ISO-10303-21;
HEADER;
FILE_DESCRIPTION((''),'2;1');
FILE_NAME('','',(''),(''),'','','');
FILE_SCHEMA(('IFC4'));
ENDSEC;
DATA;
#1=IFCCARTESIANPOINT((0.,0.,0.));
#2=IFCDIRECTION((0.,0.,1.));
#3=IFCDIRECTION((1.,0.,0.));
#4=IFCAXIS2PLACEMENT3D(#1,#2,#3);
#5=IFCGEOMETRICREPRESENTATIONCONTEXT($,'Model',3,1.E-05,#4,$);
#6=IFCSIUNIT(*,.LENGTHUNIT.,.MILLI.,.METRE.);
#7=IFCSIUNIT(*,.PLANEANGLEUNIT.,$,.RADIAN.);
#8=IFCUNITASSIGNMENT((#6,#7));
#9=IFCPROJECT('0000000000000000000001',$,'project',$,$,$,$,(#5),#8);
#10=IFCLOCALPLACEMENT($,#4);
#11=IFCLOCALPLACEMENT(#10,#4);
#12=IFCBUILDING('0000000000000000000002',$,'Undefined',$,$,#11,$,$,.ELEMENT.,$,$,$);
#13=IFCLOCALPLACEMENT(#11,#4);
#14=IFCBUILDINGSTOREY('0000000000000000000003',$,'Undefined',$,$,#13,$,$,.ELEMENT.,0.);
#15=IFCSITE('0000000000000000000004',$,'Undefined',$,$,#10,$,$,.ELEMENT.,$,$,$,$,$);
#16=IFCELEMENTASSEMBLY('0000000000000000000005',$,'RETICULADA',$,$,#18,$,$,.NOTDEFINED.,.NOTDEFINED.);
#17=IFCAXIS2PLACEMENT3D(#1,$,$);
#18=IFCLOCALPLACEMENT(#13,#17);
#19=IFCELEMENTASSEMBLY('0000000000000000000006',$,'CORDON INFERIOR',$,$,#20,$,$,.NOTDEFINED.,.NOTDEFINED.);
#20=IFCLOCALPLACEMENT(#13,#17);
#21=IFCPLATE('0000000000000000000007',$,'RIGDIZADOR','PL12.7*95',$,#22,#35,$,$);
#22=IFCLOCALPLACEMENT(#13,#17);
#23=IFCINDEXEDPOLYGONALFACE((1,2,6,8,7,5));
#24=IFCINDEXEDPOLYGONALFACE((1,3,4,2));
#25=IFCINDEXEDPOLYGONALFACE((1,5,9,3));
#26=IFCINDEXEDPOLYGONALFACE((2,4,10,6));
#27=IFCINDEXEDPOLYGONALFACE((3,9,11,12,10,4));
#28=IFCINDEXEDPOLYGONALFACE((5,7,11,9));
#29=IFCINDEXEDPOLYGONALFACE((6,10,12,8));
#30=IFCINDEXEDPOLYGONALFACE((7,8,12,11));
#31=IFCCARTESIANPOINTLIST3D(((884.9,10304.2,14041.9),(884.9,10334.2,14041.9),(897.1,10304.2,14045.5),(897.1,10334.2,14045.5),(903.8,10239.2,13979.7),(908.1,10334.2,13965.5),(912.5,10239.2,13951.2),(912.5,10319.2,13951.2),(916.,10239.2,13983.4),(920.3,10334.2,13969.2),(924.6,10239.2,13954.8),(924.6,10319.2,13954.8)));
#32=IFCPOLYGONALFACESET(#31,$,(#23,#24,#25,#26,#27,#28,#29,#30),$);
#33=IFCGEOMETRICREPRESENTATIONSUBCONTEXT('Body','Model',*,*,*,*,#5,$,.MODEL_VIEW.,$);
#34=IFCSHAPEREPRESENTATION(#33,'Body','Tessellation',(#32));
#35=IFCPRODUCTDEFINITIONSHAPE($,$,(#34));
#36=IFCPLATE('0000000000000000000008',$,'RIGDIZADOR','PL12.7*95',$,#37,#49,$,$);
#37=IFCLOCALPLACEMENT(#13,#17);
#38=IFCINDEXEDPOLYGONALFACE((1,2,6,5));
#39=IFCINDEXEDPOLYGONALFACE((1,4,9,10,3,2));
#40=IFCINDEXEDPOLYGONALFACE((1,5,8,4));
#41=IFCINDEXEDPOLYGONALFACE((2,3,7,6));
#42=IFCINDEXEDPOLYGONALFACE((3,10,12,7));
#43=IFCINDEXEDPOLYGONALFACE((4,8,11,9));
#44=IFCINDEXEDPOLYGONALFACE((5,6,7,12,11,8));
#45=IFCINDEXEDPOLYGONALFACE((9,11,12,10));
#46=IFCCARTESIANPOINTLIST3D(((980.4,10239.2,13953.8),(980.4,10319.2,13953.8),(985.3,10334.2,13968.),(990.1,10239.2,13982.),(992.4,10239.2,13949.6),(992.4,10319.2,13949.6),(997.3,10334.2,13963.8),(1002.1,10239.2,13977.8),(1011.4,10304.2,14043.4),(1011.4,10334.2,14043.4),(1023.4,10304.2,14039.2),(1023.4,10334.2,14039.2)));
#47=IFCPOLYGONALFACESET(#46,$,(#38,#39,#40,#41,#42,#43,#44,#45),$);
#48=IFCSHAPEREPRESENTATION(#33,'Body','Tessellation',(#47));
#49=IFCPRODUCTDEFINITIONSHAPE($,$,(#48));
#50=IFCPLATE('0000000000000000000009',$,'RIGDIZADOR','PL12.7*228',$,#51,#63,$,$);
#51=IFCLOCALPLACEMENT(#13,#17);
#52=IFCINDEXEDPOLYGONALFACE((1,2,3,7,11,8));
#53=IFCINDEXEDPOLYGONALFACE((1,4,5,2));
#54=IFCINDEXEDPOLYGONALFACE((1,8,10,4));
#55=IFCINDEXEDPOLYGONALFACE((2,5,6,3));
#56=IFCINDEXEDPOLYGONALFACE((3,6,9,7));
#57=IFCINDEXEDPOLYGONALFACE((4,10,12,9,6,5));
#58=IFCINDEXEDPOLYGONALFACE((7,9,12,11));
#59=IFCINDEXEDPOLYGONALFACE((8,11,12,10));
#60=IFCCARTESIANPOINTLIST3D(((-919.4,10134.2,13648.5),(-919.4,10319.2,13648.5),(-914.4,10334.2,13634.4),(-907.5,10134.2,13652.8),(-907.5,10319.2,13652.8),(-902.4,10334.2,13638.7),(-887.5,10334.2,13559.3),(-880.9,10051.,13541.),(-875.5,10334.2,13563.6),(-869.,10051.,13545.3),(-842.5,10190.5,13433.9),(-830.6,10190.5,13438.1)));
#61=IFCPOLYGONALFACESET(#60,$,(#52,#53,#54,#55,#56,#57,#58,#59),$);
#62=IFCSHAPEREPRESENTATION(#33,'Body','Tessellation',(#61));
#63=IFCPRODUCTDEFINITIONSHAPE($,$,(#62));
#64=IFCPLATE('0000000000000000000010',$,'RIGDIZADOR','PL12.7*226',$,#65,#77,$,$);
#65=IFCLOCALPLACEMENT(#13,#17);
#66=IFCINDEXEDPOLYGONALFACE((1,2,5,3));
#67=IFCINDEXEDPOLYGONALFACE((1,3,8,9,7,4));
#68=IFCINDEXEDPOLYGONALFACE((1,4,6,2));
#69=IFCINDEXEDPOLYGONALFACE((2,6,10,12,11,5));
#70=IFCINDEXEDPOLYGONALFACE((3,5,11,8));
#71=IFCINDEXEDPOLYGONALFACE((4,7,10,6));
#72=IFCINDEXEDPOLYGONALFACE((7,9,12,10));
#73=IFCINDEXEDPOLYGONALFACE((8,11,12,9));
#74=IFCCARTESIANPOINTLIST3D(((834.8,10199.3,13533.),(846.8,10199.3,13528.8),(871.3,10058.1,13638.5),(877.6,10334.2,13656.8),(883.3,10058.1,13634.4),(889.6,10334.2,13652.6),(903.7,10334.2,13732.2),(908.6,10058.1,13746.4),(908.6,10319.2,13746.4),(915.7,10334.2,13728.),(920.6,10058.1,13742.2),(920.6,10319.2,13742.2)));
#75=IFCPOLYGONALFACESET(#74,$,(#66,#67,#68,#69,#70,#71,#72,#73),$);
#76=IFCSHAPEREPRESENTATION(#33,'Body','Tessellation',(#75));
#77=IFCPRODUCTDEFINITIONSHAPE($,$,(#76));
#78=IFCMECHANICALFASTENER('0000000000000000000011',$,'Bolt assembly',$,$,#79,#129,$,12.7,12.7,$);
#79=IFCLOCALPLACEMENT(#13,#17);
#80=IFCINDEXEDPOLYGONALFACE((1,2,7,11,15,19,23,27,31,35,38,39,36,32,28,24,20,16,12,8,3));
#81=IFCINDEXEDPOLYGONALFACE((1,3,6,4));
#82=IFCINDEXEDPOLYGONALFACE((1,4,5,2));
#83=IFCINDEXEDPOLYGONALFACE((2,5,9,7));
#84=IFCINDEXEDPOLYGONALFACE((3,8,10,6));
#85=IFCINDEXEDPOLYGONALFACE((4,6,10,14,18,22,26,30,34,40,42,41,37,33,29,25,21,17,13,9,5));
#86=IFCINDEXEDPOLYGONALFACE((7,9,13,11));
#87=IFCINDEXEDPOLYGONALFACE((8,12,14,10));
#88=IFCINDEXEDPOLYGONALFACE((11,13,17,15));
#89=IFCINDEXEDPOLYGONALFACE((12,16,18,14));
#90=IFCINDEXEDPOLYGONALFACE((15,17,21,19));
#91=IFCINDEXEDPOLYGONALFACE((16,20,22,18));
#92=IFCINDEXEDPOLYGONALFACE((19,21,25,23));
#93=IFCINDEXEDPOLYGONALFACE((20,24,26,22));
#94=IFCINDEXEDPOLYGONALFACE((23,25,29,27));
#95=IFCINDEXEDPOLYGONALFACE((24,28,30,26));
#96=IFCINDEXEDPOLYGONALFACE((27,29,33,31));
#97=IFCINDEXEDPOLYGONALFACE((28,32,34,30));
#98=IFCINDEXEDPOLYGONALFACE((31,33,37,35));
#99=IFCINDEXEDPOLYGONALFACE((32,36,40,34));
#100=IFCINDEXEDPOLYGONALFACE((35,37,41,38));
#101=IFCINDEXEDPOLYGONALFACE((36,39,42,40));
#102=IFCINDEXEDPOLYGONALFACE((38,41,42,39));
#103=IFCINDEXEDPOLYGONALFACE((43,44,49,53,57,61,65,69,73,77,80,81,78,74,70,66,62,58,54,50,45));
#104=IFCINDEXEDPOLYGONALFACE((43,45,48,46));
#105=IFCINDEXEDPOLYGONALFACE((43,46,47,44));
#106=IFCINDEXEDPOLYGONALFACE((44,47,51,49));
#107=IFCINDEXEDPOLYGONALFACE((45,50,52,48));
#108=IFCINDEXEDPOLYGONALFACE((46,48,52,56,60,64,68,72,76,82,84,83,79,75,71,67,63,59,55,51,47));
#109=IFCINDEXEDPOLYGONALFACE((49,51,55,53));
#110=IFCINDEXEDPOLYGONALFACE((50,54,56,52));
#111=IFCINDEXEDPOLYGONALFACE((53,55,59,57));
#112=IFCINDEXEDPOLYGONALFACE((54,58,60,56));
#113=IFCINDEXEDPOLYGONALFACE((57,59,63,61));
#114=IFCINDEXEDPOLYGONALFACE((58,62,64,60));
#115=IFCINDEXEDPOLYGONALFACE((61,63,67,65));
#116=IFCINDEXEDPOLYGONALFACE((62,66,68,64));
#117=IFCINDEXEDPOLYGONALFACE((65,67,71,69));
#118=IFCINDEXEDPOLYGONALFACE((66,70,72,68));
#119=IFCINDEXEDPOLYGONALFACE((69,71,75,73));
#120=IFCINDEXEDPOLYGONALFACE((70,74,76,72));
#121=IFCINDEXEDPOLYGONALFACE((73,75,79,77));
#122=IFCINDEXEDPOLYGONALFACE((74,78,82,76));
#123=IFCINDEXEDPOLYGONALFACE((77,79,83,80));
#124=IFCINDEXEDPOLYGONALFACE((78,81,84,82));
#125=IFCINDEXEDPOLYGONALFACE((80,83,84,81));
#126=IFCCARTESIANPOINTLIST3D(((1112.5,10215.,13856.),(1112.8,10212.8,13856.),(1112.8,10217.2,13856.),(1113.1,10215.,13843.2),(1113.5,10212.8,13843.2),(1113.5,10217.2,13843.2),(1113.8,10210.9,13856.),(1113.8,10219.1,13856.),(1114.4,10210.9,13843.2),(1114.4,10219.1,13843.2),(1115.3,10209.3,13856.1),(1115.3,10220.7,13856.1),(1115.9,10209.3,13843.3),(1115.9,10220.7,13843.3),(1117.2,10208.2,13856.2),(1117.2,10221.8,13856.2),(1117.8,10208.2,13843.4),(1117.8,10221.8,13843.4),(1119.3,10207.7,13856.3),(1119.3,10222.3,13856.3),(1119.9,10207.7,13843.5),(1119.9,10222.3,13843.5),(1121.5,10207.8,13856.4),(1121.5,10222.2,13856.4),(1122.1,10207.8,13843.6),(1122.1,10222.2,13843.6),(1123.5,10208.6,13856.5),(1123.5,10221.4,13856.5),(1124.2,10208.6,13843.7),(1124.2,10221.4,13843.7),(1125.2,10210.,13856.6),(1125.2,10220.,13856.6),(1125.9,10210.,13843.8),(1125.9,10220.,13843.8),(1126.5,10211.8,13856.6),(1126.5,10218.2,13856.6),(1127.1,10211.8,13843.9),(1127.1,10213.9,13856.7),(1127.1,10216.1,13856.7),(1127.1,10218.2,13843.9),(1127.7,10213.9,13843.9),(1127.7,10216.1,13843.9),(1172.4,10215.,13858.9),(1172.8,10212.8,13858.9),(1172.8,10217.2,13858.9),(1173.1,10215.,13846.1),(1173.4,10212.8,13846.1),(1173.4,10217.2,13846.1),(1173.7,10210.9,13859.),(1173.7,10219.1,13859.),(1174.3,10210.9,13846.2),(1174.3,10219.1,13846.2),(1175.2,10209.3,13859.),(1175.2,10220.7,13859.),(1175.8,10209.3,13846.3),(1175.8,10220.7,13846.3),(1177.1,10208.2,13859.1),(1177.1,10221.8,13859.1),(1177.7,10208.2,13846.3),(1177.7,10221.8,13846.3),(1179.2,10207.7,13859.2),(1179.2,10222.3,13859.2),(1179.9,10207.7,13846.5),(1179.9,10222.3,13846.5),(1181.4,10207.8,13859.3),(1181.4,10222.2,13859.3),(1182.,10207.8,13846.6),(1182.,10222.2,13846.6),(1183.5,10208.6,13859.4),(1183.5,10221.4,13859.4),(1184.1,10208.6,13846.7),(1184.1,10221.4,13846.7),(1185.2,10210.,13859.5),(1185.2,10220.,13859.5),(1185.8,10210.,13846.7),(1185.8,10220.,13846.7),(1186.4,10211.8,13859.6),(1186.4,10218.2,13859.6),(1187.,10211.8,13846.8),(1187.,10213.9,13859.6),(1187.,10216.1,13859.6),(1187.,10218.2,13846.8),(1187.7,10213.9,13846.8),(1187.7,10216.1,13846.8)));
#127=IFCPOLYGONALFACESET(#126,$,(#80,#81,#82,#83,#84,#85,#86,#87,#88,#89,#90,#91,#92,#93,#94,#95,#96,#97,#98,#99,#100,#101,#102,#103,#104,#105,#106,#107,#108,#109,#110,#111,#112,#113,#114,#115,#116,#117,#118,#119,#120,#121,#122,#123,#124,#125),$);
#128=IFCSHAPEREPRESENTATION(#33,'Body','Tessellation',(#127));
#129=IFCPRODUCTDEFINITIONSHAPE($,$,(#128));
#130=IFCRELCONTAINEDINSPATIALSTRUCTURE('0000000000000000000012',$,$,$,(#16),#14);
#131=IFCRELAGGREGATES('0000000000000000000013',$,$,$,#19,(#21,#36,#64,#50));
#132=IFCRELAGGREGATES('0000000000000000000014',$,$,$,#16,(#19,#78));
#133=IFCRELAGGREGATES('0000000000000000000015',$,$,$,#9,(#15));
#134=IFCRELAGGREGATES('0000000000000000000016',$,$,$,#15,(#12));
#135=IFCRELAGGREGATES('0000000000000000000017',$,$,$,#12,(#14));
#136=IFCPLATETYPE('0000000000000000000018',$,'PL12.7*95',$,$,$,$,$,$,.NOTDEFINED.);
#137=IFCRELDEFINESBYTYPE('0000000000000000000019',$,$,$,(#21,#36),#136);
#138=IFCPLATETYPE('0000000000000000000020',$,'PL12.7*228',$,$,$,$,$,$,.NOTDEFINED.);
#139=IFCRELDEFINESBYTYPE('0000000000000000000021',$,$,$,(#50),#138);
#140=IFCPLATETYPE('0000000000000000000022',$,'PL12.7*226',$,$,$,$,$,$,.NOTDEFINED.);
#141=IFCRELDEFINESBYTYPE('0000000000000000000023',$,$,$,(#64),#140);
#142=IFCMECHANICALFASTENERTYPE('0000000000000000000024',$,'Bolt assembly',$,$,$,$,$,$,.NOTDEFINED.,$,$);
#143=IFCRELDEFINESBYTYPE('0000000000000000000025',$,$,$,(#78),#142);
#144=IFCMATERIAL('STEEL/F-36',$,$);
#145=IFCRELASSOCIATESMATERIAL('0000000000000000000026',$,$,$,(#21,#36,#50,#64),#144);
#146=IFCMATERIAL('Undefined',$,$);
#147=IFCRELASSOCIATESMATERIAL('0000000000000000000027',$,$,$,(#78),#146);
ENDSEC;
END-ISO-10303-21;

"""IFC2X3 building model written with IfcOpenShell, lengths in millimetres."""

from ifc_helpers import new_model, si_unit, frame, origin_with_axes, origin_2d_with_axis, place, context, subcontext, project, spatial, polyline, circle, outline, extrude, source, transform, mapped, material, type_object, element, aggregate, save


model = new_model("IFC2X3")

# Units and contexts
model_context = context("Model", 3, precision=1e-05, world=origin_with_axes())
body_context = subcontext(model_context, "Body", "Model", "MODEL_VIEW")
ifc_project = project(units=[si_unit("LENGTHUNIT", "METRE", prefix="MILLI"), si_unit("PLANEANGLEUNIT", "RADIAN")], contexts=[model_context])

# Site, building, storey
site_placement = place(None, origin_with_axes())
site = spatial("IfcSite", under=ifc_project, at=site_placement, Name="Undefined", CompositionType="ELEMENT")
building_placement = place(site_placement, origin_with_axes())
building = spatial("IfcBuilding", under=site, at=building_placement, Name="Undefined", CompositionType="ELEMENT")
storey_placement = place(building_placement, origin_with_axes())
storey = spatial("IfcBuildingStorey", under=building, at=storey_placement, Name="Undefined", CompositionType="ELEMENT", Elevation=0.0)

# Element assemblies
assembly_1_placement = place(storey_placement, origin_with_axes())
assembly_1 = element("IfcElementAssembly", 1, at=assembly_1_placement, inside=storey, Name="RETICULADA", AssemblyPlace="NOTDEFINED", PredefinedType="NOTDEFINED")
assembly_2_placement = place(assembly_1_placement, origin_with_axes())
assembly_2 = element("IfcElementAssembly", 2, at=assembly_2_placement, Name="CORDON INFERIOR", AssemblyPlace="NOTDEFINED", PredefinedType="NOTDEFINED")
ifc_material_1 = material(Name="STEEL/F-36")

# Plates
plate_type_1 = type_object("IfcPlateType", Name="PL12.7*95", PredefinedType="NOTDEFINED")
plate_1_placement = place(assembly_2_placement, frame((891.0, 10334.2, 14043.7), z_axis=(-0.956743, 0.0, -0.290936), x_axis=(0.290936, 0.0, -0.956743)))
plate_1 = element("IfcPlate", 3, at=plate_1_placement, type_object=plate_type_1, material=ifc_material_1, Name="RIGDIZADOR", Description="PL12.7*95", context=body_context, shape_type="SweptSolid", body=[
    extrude(outline(polyline([(0.0, 0.0), (79.8, 0.0), (94.8, 15.0), (94.8, 95.0), (65.0, 95.0), (0.0, 30.0), (0.0, 0.0)])), frame((0.0, 0.0, -6.3), z_axis=(0.0, 0.0, 1.0), x_axis=(1.0, 0.0, 0.0)), (0.0, 0.0, 1.0), 12.7),
])
plate_2_placement = place(assembly_2_placement, frame((1017.4, 10334.2, 14041.3), z_axis=(-0.945029, 0.0, 0.326987), x_axis=(-0.326987, 0.0, -0.945029)))
plate_2 = element("IfcPlate", 4, at=plate_2_placement, type_object=plate_type_1, material=ifc_material_1, Name="RIGDIZADOR", Description="PL12.7*95", context=body_context, shape_type="SweptSolid", body=[
    extrude(outline(polyline([(0.0, 0.0), (79.8, 0.0), (94.8, 15.0), (94.8, 95.0), (65.0, 95.0), (0.0, 30.0), (0.0, 0.0)])), frame((0.0, 0.0, -6.3), z_axis=(0.0, 0.0, 1.0), x_axis=(1.0, 0.0, 0.0)), (0.0, 0.0, 1.0), 12.7),
])
plate_type_2 = type_object("IfcPlateType", Name="PL12.7*228", PredefinedType="NOTDEFINED")
plate_3_placement = place(assembly_2_placement, frame((-881.5, 10334.2, 13561.4), z_axis=(0.941406, 0.0, 0.337276), x_axis=(-0.337276, 0.0, 0.941406)))
plate_3 = element("IfcPlate", 5, at=plate_3_placement, type_object=plate_type_2, material=ifc_material_1, Name="RIGDIZADOR", Description="PL12.7*228", context=body_context, shape_type="SweptSolid", body=[
    extrude(outline(polyline([(0.0, 0.0), (79.8, 0.0), (94.8, 15.0), (94.8, 200.0), (-19.4, 283.2), (-133.2, 143.7), (0.0, 0.0)])), frame((0.0, 0.0, -6.3), z_axis=(0.0, 0.0, 1.0), x_axis=(1.0, 0.0, 0.0)), (0.0, 0.0, 1.0), 12.7),
])
plate_type_3 = type_object("IfcPlateType", Name="PL12.7*226", PredefinedType="NOTDEFINED")
plate_4_placement = place(assembly_2_placement, frame((883.6, 10334.2, 13654.7), z_axis=(0.945029, 0.0, -0.326987), x_axis=(0.326987, 0.0, 0.945029)))
plate_4 = element("IfcPlate", 6, at=plate_4_placement, type_object=plate_type_3, material=ifc_material_1, Name="RIGDIZADOR", Description="PL12.7*226", context=body_context, shape_type="SweptSolid", body=[
    extrude(outline(polyline([(0.0, 0.0), (79.8, 0.0), (94.8, 15.0), (94.8, 276.1), (-19.3, 276.1), (-131.0, 134.9), (0.0, 0.0)])), frame((0.0, 0.0, -6.3), z_axis=(0.0, 0.0, 1.0), x_axis=(1.0, 0.0, 0.0)), (0.0, 0.0, 1.0), 12.7),
])
aggregate(assembly_2, [plate_1, plate_2, plate_4, plate_3])

# Mechanical fastener
ifc_material_2 = material(Name="Undefined")
mechanical_fastener_type = type_object("IfcMechanicalFastenerType", Name="Bolt assembly")
shared_shape_1 = source(origin_with_axes(), body_context, "Body", "SweptSolid", [
    extrude(circle(Radius=7.3, at=origin_2d_with_axis()), frame((0.0, 0.0, 0.0), z_axis=(0.0, 1.0, 0.0), x_axis=(1.0, 0.0, 0.0)), (0.0, 0.0, 1.0), 12.8),
])
mechanical_fastener_1_placement = place(assembly_1_placement, frame((1179.8, 10215.0, 13859.3), z_axis=(0.0, -1.0, 0.0), x_axis=(-0.998794, 0.0, -0.049094)))
mechanical_fastener_1 = element("IfcMechanicalFastener", 7, at=mechanical_fastener_1_placement, type_object=mechanical_fastener_type, material=ifc_material_2, Name="Bolt assembly", NominalDiameter=12.7, NominalLength=12.7, context=body_context, shape_type="MappedRepresentation", body=[
    mapped(shared_shape_1, transform((0.0, 0.0, 0.0))),
    mapped(shared_shape_1, transform((60.0, 0.0, 0.0))),
])
aggregate(assembly_1, [assembly_2, mechanical_fastener_1])

save(model, "model.ifc")
